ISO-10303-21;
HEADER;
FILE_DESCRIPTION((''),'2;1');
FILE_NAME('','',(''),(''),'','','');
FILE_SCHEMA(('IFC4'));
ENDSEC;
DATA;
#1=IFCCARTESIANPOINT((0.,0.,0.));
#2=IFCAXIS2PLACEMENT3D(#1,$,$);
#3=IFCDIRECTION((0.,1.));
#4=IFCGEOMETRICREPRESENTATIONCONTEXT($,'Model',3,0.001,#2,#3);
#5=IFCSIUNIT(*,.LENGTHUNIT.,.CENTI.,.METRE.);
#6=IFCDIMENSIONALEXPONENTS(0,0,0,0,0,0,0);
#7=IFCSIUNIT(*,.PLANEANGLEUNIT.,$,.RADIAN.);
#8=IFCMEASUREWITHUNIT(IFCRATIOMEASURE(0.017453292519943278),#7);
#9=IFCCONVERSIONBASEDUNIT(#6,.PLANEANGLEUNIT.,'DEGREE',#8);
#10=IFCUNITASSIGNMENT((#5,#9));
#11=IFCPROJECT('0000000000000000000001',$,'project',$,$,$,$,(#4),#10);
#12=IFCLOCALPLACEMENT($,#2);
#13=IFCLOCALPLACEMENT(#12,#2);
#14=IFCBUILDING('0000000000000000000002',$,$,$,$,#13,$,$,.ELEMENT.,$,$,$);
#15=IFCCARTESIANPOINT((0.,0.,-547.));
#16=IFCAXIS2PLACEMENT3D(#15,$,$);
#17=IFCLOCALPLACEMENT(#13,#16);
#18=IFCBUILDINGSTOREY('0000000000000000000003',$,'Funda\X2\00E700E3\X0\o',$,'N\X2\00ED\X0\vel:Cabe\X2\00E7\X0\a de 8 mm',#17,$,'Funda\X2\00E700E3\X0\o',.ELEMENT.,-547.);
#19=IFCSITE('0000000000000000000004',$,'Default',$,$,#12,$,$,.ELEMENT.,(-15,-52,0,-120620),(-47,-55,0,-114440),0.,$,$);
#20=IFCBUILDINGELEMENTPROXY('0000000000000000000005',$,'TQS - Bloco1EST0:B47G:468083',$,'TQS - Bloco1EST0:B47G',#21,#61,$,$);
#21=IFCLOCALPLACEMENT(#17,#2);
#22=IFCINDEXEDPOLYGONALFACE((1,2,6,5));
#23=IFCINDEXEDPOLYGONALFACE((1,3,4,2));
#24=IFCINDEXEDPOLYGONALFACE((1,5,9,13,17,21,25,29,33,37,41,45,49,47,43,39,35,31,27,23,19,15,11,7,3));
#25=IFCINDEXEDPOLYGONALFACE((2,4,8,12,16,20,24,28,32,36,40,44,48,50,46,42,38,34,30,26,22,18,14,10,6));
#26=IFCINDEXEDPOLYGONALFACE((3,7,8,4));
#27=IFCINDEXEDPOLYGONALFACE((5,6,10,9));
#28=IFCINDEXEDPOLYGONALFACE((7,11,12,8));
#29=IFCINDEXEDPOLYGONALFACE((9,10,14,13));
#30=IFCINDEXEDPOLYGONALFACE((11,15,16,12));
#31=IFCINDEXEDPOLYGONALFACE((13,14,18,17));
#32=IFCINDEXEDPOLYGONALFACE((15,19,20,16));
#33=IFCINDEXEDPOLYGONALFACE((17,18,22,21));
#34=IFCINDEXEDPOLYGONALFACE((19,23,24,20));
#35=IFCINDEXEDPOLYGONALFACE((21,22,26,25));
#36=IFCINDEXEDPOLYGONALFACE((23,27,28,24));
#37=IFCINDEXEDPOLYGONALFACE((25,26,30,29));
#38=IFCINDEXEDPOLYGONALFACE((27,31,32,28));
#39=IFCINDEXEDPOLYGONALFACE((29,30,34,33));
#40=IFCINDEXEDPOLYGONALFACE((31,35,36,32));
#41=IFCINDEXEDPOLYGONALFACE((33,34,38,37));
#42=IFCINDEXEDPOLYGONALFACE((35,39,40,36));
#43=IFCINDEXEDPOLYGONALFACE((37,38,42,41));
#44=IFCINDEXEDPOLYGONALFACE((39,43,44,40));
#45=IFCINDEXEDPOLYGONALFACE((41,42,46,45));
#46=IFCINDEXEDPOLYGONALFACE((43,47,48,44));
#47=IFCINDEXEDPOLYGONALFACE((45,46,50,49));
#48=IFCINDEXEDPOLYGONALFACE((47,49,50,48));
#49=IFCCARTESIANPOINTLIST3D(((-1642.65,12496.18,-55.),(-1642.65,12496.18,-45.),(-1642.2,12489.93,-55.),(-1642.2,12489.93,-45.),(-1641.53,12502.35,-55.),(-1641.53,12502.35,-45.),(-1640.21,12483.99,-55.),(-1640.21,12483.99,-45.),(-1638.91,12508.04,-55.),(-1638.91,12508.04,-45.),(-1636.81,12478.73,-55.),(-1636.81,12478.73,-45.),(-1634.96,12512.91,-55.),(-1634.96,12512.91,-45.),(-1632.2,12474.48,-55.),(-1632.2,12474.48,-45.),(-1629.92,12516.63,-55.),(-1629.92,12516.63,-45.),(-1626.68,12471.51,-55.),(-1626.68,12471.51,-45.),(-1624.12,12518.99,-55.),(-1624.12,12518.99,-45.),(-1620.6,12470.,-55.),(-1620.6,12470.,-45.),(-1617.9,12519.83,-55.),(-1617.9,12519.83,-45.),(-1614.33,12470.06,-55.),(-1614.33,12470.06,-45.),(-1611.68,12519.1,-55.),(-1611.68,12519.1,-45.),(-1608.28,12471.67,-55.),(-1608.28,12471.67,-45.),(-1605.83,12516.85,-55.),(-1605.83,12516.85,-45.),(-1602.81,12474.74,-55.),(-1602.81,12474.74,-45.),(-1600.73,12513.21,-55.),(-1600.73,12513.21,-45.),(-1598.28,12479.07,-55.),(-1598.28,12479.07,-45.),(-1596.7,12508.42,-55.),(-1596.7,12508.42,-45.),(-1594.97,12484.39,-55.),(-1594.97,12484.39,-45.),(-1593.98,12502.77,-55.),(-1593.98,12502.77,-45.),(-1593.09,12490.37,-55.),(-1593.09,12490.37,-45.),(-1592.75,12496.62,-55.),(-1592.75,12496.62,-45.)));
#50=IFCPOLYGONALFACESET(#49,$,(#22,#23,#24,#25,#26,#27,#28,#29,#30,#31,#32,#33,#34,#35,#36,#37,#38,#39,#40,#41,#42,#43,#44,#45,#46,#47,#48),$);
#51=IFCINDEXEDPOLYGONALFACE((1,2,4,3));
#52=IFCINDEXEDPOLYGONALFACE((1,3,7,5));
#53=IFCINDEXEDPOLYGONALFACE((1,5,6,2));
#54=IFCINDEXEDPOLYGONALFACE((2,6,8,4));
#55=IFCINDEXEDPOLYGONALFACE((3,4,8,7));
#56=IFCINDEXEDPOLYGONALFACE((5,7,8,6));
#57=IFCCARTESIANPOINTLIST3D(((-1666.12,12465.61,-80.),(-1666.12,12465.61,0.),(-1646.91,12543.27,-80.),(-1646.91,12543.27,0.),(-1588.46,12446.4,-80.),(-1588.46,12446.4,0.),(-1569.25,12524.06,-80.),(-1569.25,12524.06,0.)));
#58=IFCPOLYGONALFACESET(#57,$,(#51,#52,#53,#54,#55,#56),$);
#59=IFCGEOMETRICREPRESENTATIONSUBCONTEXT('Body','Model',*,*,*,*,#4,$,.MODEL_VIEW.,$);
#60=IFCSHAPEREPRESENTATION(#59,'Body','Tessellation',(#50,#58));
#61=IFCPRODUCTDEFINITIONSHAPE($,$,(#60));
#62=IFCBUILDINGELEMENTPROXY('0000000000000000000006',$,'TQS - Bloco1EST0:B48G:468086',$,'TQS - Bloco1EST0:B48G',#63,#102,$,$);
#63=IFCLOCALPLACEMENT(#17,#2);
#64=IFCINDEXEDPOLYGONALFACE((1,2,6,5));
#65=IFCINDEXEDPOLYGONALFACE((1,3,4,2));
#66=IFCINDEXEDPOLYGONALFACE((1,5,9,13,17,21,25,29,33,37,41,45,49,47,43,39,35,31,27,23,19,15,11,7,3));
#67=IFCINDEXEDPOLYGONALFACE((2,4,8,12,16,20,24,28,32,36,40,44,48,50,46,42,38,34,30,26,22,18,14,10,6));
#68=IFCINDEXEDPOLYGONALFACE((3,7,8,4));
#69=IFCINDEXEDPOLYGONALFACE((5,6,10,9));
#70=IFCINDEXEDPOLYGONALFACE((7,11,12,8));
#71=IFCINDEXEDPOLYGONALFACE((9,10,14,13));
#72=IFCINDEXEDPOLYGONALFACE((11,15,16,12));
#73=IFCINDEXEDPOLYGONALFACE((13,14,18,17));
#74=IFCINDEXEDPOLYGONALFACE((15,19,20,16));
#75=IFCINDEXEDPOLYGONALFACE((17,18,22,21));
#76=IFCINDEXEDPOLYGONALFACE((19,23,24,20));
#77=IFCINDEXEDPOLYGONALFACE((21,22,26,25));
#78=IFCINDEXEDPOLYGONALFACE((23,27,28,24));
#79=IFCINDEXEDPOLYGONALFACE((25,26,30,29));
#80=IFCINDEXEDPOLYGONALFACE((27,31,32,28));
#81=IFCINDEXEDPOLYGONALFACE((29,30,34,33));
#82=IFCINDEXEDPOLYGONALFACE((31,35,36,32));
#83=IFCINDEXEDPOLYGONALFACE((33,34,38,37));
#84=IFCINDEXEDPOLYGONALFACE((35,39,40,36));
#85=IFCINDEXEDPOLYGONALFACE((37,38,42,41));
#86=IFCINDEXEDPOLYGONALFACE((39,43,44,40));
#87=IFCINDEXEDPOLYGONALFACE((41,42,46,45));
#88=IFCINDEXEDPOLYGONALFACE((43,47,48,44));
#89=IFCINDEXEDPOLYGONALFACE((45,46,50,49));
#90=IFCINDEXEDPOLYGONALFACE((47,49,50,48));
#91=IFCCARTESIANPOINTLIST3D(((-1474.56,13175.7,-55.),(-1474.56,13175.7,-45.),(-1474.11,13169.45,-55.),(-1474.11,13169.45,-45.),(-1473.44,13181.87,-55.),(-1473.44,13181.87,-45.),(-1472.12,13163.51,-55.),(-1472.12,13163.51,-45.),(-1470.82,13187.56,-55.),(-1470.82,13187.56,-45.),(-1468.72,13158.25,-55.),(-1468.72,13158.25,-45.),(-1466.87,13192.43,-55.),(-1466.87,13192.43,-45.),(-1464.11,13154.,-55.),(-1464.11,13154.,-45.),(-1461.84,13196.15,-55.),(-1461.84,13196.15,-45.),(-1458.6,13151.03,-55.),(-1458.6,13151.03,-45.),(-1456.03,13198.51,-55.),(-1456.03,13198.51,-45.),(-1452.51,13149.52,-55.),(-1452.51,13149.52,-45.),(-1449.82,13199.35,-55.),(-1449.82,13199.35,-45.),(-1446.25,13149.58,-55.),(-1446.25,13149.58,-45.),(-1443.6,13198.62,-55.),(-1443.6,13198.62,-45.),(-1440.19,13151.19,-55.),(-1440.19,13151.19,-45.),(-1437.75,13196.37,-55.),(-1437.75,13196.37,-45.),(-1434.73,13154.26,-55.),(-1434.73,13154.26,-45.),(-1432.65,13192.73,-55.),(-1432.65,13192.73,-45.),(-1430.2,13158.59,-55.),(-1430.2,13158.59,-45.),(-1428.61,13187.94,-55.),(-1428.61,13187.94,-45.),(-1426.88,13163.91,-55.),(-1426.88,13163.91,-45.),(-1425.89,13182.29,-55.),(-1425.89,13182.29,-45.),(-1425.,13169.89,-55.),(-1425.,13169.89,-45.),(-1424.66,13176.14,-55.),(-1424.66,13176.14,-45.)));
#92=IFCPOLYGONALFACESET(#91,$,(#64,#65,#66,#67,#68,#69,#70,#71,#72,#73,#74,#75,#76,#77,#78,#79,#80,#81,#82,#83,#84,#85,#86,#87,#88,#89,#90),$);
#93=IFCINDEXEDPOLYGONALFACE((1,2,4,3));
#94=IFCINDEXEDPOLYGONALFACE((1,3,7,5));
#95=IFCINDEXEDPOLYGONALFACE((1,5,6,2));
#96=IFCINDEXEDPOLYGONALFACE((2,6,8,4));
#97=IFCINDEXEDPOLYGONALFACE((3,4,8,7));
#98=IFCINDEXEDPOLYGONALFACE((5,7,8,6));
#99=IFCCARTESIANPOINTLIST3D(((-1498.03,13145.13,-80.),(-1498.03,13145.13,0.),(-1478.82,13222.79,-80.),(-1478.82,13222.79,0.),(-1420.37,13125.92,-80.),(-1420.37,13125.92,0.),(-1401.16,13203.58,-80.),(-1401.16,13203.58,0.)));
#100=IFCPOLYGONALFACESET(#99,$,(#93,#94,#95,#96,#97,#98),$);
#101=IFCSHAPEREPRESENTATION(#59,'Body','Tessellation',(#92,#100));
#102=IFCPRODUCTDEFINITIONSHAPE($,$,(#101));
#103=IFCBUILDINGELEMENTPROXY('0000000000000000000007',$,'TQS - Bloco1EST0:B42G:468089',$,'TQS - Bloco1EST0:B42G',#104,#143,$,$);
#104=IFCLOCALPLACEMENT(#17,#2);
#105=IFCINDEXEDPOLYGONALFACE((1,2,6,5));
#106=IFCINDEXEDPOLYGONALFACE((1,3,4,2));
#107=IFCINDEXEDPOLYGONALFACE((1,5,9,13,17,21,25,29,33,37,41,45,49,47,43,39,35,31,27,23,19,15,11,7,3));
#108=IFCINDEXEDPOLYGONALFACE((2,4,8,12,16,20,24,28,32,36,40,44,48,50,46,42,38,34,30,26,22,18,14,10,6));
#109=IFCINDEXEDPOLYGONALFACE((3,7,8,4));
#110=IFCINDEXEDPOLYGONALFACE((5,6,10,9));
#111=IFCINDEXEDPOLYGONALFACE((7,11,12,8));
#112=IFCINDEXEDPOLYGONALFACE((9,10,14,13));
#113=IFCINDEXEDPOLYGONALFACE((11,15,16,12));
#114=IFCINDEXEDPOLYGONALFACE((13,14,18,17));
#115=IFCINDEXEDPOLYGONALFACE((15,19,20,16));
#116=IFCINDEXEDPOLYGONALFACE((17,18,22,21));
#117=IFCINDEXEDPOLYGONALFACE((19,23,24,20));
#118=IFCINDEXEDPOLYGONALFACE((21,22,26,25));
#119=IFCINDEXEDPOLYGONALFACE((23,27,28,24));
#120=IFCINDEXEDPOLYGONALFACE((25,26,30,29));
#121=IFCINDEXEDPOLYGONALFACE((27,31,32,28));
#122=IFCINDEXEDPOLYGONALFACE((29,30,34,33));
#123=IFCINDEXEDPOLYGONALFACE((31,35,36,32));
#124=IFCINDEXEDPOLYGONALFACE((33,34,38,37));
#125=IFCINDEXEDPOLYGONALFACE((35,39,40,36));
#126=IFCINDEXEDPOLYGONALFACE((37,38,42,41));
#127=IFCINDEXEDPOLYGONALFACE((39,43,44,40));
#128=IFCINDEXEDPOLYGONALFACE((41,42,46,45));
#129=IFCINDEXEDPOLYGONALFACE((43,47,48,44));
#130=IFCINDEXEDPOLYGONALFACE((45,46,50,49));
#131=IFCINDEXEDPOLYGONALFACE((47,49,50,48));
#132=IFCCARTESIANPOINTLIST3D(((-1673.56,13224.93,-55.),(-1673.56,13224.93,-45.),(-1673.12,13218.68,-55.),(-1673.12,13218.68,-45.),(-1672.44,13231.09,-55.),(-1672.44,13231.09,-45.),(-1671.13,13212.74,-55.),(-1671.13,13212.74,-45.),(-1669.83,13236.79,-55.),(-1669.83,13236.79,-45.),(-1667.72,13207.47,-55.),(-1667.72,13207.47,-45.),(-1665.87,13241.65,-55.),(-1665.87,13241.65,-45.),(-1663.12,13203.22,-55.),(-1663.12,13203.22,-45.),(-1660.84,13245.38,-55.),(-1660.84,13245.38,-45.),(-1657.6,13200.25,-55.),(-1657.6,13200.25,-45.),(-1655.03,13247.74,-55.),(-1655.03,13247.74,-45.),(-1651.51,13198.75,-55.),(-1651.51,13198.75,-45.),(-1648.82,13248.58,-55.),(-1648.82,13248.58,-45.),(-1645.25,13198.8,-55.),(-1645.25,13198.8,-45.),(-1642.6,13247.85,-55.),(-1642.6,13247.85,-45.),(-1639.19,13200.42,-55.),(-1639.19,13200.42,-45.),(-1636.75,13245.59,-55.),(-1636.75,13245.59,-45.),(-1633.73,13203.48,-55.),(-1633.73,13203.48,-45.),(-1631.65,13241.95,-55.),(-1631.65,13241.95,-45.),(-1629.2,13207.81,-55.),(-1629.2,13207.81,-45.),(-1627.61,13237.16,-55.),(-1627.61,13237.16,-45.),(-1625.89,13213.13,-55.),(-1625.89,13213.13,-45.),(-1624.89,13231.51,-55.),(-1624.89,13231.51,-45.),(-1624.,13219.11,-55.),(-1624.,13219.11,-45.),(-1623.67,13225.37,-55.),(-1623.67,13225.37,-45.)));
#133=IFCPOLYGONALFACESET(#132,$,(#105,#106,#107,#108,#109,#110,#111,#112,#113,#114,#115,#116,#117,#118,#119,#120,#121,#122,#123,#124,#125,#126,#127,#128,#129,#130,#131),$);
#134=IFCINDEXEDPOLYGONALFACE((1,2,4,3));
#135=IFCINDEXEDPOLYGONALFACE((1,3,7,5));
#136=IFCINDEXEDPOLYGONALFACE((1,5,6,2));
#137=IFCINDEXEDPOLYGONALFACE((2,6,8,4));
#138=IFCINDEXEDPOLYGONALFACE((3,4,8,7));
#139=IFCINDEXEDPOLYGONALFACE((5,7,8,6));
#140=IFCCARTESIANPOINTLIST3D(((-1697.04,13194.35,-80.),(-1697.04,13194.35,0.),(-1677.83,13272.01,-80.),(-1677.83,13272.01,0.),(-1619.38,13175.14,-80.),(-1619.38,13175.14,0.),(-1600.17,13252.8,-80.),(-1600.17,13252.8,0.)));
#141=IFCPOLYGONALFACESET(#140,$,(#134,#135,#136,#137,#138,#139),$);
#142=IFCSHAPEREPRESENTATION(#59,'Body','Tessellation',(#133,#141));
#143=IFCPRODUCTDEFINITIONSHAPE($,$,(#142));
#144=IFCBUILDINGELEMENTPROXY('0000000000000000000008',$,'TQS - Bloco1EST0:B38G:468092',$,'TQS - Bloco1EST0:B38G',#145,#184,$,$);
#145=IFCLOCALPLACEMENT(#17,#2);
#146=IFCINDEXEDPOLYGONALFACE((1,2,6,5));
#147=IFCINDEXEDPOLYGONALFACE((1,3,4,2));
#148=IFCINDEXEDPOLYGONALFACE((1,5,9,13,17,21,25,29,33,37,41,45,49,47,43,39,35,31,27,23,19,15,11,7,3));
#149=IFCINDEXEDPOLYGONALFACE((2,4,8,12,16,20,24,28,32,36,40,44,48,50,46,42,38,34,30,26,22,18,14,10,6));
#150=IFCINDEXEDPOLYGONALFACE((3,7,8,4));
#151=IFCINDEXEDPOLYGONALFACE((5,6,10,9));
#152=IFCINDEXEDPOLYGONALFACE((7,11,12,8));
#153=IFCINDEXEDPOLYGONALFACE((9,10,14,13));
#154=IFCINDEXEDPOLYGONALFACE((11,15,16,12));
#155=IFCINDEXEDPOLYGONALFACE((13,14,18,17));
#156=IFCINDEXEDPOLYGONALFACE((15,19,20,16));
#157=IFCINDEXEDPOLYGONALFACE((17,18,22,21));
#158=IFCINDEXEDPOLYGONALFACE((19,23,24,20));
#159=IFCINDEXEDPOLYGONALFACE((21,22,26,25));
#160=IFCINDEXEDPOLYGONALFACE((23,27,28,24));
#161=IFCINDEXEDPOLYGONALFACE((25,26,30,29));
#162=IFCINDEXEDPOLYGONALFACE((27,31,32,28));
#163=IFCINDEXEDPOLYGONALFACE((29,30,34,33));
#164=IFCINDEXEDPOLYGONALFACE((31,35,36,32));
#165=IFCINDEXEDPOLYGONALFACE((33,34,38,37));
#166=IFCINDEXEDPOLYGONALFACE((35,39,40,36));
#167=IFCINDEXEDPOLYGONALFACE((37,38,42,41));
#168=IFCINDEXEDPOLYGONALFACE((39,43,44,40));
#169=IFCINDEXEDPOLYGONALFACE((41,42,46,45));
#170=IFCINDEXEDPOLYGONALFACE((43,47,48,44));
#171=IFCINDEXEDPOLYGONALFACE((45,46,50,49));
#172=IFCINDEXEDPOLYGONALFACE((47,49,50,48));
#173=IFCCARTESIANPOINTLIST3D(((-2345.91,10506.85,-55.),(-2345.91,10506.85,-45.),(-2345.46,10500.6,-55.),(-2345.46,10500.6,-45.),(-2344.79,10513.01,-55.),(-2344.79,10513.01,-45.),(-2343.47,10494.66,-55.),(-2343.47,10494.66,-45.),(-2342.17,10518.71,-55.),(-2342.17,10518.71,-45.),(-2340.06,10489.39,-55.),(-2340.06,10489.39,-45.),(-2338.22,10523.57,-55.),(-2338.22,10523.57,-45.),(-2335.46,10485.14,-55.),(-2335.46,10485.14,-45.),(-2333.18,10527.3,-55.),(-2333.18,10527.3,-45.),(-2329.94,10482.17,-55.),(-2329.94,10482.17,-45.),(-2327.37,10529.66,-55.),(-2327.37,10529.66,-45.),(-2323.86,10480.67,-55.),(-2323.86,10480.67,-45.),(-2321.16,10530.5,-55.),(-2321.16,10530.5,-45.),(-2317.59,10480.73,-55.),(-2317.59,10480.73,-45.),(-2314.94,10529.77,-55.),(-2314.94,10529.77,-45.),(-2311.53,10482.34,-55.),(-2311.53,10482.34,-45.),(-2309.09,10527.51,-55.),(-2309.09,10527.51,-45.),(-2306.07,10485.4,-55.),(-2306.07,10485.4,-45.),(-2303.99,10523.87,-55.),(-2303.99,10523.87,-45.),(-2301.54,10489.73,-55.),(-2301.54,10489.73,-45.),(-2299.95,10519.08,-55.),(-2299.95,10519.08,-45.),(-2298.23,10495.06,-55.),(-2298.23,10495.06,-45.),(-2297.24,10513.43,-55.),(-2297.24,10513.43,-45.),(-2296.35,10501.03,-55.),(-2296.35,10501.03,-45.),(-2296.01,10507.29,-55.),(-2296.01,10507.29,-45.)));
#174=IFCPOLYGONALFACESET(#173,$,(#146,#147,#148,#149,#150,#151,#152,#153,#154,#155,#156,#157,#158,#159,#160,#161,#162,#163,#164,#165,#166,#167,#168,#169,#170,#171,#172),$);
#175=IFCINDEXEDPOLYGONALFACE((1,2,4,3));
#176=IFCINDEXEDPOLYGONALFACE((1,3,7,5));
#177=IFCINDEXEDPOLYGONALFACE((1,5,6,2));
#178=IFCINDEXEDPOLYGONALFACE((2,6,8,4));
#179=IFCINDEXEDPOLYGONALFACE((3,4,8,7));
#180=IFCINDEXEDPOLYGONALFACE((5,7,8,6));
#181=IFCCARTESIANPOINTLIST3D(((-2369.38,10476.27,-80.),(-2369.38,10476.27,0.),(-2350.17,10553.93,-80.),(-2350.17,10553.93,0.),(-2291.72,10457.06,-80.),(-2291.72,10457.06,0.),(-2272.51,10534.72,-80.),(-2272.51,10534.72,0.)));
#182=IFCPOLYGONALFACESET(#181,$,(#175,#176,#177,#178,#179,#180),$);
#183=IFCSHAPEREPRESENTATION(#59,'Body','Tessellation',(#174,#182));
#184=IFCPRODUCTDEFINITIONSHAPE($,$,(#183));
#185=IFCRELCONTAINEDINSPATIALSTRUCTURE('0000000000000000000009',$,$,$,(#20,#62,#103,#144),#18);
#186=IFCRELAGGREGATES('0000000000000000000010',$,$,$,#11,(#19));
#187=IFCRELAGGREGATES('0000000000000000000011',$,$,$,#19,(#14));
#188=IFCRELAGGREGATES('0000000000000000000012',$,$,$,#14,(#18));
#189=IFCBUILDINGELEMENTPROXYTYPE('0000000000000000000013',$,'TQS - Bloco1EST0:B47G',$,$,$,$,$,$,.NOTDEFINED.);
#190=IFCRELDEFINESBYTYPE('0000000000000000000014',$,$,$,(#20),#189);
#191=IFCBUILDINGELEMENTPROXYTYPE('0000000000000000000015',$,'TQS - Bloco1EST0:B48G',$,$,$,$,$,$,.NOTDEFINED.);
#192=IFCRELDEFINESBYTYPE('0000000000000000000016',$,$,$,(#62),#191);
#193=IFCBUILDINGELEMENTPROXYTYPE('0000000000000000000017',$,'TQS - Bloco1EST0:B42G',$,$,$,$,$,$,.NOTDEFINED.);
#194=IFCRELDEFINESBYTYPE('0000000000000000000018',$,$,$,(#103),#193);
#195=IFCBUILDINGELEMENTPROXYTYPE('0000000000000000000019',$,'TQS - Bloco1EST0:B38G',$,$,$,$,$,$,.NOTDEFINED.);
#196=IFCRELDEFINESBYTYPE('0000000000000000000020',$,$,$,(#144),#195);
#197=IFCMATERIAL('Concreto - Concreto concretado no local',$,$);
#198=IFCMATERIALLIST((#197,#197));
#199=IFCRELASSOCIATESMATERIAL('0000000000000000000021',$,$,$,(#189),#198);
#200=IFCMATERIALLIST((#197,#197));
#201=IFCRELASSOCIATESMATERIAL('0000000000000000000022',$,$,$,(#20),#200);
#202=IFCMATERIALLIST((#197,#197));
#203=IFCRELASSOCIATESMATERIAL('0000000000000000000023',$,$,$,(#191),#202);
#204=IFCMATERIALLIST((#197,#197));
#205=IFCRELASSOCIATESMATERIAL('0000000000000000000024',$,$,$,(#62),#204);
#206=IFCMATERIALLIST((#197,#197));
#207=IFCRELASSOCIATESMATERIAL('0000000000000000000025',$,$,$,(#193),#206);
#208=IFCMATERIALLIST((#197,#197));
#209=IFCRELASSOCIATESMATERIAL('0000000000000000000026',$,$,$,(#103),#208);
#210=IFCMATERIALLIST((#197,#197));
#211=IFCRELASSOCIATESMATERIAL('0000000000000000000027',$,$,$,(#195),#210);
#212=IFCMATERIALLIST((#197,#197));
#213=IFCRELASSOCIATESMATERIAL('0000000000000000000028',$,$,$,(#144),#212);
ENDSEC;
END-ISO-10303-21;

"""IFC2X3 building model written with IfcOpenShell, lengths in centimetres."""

from ifc_helpers import new_model, entity, si_unit, converted_unit, direction, frame, frame_2d, origin, origin_2d_with_axis, place, context, subcontext, project, spatial, rectangle, circle, extrude, source, transform, mapped, material, material_list, type_object, type_shapes, element, save


model = new_model("IFC2X3")

# Units and contexts
model_context = context("Model", 3, precision=0.001, world=origin(), true_north=direction((0.0, 1.0)))
body_context = subcontext(model_context, "Body", "Model", "MODEL_VIEW")
ifc_project = project(units=[si_unit("LENGTHUNIT", "METRE", prefix="CENTI"), converted_unit("PLANEANGLEUNIT", "DEGREE", entity("IfcRatioMeasure", 0.017453292519943278), si_unit("PLANEANGLEUNIT", "RADIAN"), dimensions=[0, 0, 0, 0, 0, 0, 0])], contexts=[model_context])

# Site, building, storey
site_placement = place(None, origin())
site = spatial("IfcSite", under=ifc_project, at=site_placement, Name="Default", CompositionType="ELEMENT", RefLatitude=(-15, -52, 0, -120620), RefLongitude=(-47, -55, 0, -114440), RefElevation=0.0)
building_placement = place(site_placement, origin())
building = spatial("IfcBuilding", under=site, at=building_placement, CompositionType="ELEMENT")
storey_placement = place(building_placement, frame((0.0, 0.0, -547.0)))
storey = spatial("IfcBuildingStorey", under=building, at=storey_placement, Name="Fundação", ObjectType="Nível:Cabeça de 8 mm", LongName="Fundação", CompositionType="ELEMENT", Elevation=-547.0)

# Building element proxies
ifc_material_1 = material(Name="Concreto - Concreto concretado no local")
ifc_material_list_1 = material_list([ifc_material_1, ifc_material_1])
ifc_material_list_2 = material_list([ifc_material_1, ifc_material_1])
building_element_proxy_type_1 = type_object("IfcBuildingElementProxyType", Name="TQS - Bloco1EST0:B47G", PredefinedType="NOTDEFINED", material=ifc_material_list_2)
shared_shape_1 = source(origin(), body_context, "Body", "SweptSolid", [
    extrude(circle(Radius=25.0, at=frame_2d((0.0, 0.0), x_axis=(1.0, 0.0))), frame((0.0, 0.0, -55.0)), (0.0, 0.0, 1.0), 10.0),
    extrude(rectangle(XDim=80.0, YDim=80.0, at=origin_2d_with_axis()), frame((0.0, 0.0, -80.0), z_axis=(0.0, 0.0, 1.0), x_axis=(-1.0, 0.0, 0.0)), (0.0, 0.0, 1.0), 80.0),
])
type_shapes(building_element_proxy_type_1, [shared_shape_1])
proxy_1_placement = place(storey_placement, frame((-1617.68, 12494.83, 0.0), z_axis=(0.0, 0.0, 1.0), x_axis=(0.240122, 0.970743, 0.0)))
element("IfcBuildingElementProxy", 1, at=proxy_1_placement, inside=storey, type_object=building_element_proxy_type_1, material=ifc_material_list_1, Name="TQS - Bloco1EST0:B47G:468083", ObjectType="TQS - Bloco1EST0:B47G", context=body_context, shape_type="MappedRepresentation", body=[
    mapped(shared_shape_1, transform((0.0, 0.0, 0.0), scale=1.0)),
])
ifc_material_list_3 = material_list([ifc_material_1, ifc_material_1])
ifc_material_list_4 = material_list([ifc_material_1, ifc_material_1])
building_element_proxy_type_2 = type_object("IfcBuildingElementProxyType", Name="TQS - Bloco1EST0:B48G", PredefinedType="NOTDEFINED", material=ifc_material_list_4)
shared_shape_2 = source(origin(), body_context, "Body", "SweptSolid", [
    extrude(circle(Radius=25.0, at=frame_2d((0.0, 0.0), x_axis=(1.0, 0.0))), frame((0.0, 0.0, -55.0)), (0.0, 0.0, 1.0), 10.0),
    extrude(rectangle(XDim=80.0, YDim=80.0, at=origin_2d_with_axis()), frame((0.0, 0.0, -80.0), z_axis=(0.0, 0.0, 1.0), x_axis=(-1.0, 0.0, 0.0)), (0.0, 0.0, 1.0), 80.0),
])
type_shapes(building_element_proxy_type_2, [shared_shape_2])
proxy_2_placement = place(storey_placement, frame((-1449.6, 13174.35, 0.0), z_axis=(0.0, 0.0, 1.0), x_axis=(0.240122, 0.970743, 0.0)))
element("IfcBuildingElementProxy", 2, at=proxy_2_placement, inside=storey, type_object=building_element_proxy_type_2, material=ifc_material_list_3, Name="TQS - Bloco1EST0:B48G:468086", ObjectType="TQS - Bloco1EST0:B48G", context=body_context, shape_type="MappedRepresentation", body=[
    mapped(shared_shape_2, transform((0.0, 0.0, 0.0), scale=1.0)),
])
ifc_material_list_5 = material_list([ifc_material_1, ifc_material_1])
ifc_material_list_6 = material_list([ifc_material_1, ifc_material_1])
building_element_proxy_type_3 = type_object("IfcBuildingElementProxyType", Name="TQS - Bloco1EST0:B42G", PredefinedType="NOTDEFINED", material=ifc_material_list_6)
shared_shape_3 = source(origin(), body_context, "Body", "SweptSolid", [
    extrude(circle(Radius=25.0, at=frame_2d((0.0, 0.0), x_axis=(1.0, 0.0))), frame((0.0, 0.0, -55.0)), (0.0, 0.0, 1.0), 10.0),
    extrude(rectangle(XDim=80.0, YDim=80.0, at=origin_2d_with_axis()), frame((0.0, 0.0, -80.0), z_axis=(0.0, 0.0, 1.0), x_axis=(-1.0, 0.0, 0.0)), (0.0, 0.0, 1.0), 80.0),
])
type_shapes(building_element_proxy_type_3, [shared_shape_3])
proxy_3_placement = place(storey_placement, frame((-1648.6, 13223.58, 0.0), z_axis=(0.0, 0.0, 1.0), x_axis=(0.240122, 0.970743, 0.0)))
element("IfcBuildingElementProxy", 3, at=proxy_3_placement, inside=storey, type_object=building_element_proxy_type_3, material=ifc_material_list_5, Name="TQS - Bloco1EST0:B42G:468089", ObjectType="TQS - Bloco1EST0:B42G", context=body_context, shape_type="MappedRepresentation", body=[
    mapped(shared_shape_3, transform((0.0, 0.0, 0.0), scale=1.0)),
])
ifc_material_list_7 = material_list([ifc_material_1, ifc_material_1])
ifc_material_list_8 = material_list([ifc_material_1, ifc_material_1])
building_element_proxy_type_4 = type_object("IfcBuildingElementProxyType", Name="TQS - Bloco1EST0:B38G", PredefinedType="NOTDEFINED", material=ifc_material_list_8)
shared_shape_4 = source(origin(), body_context, "Body", "SweptSolid", [
    extrude(circle(Radius=25.0, at=frame_2d((0.0, 0.0), x_axis=(1.0, 0.0))), frame((0.0, 0.0, -55.0)), (0.0, 0.0, 1.0), 10.0),
    extrude(rectangle(XDim=80.0, YDim=80.0, at=origin_2d_with_axis()), frame((0.0, 0.0, -80.0), z_axis=(0.0, 0.0, 1.0), x_axis=(-1.0, 0.0, 0.0)), (0.0, 0.0, 1.0), 80.0),
])
type_shapes(building_element_proxy_type_4, [shared_shape_4])
proxy_4_placement = place(storey_placement, frame((-2320.94, 10505.5, 0.0), z_axis=(0.0, 0.0, 1.0), x_axis=(0.240122, 0.970743, 0.0)))
element("IfcBuildingElementProxy", 4, at=proxy_4_placement, inside=storey, type_object=building_element_proxy_type_4, material=ifc_material_list_7, Name="TQS - Bloco1EST0:B38G:468092", ObjectType="TQS - Bloco1EST0:B38G", context=body_context, shape_type="MappedRepresentation", body=[
    mapped(shared_shape_4, transform((0.0, 0.0, 0.0), scale=1.0)),
])

save(model, "model.ifc")
